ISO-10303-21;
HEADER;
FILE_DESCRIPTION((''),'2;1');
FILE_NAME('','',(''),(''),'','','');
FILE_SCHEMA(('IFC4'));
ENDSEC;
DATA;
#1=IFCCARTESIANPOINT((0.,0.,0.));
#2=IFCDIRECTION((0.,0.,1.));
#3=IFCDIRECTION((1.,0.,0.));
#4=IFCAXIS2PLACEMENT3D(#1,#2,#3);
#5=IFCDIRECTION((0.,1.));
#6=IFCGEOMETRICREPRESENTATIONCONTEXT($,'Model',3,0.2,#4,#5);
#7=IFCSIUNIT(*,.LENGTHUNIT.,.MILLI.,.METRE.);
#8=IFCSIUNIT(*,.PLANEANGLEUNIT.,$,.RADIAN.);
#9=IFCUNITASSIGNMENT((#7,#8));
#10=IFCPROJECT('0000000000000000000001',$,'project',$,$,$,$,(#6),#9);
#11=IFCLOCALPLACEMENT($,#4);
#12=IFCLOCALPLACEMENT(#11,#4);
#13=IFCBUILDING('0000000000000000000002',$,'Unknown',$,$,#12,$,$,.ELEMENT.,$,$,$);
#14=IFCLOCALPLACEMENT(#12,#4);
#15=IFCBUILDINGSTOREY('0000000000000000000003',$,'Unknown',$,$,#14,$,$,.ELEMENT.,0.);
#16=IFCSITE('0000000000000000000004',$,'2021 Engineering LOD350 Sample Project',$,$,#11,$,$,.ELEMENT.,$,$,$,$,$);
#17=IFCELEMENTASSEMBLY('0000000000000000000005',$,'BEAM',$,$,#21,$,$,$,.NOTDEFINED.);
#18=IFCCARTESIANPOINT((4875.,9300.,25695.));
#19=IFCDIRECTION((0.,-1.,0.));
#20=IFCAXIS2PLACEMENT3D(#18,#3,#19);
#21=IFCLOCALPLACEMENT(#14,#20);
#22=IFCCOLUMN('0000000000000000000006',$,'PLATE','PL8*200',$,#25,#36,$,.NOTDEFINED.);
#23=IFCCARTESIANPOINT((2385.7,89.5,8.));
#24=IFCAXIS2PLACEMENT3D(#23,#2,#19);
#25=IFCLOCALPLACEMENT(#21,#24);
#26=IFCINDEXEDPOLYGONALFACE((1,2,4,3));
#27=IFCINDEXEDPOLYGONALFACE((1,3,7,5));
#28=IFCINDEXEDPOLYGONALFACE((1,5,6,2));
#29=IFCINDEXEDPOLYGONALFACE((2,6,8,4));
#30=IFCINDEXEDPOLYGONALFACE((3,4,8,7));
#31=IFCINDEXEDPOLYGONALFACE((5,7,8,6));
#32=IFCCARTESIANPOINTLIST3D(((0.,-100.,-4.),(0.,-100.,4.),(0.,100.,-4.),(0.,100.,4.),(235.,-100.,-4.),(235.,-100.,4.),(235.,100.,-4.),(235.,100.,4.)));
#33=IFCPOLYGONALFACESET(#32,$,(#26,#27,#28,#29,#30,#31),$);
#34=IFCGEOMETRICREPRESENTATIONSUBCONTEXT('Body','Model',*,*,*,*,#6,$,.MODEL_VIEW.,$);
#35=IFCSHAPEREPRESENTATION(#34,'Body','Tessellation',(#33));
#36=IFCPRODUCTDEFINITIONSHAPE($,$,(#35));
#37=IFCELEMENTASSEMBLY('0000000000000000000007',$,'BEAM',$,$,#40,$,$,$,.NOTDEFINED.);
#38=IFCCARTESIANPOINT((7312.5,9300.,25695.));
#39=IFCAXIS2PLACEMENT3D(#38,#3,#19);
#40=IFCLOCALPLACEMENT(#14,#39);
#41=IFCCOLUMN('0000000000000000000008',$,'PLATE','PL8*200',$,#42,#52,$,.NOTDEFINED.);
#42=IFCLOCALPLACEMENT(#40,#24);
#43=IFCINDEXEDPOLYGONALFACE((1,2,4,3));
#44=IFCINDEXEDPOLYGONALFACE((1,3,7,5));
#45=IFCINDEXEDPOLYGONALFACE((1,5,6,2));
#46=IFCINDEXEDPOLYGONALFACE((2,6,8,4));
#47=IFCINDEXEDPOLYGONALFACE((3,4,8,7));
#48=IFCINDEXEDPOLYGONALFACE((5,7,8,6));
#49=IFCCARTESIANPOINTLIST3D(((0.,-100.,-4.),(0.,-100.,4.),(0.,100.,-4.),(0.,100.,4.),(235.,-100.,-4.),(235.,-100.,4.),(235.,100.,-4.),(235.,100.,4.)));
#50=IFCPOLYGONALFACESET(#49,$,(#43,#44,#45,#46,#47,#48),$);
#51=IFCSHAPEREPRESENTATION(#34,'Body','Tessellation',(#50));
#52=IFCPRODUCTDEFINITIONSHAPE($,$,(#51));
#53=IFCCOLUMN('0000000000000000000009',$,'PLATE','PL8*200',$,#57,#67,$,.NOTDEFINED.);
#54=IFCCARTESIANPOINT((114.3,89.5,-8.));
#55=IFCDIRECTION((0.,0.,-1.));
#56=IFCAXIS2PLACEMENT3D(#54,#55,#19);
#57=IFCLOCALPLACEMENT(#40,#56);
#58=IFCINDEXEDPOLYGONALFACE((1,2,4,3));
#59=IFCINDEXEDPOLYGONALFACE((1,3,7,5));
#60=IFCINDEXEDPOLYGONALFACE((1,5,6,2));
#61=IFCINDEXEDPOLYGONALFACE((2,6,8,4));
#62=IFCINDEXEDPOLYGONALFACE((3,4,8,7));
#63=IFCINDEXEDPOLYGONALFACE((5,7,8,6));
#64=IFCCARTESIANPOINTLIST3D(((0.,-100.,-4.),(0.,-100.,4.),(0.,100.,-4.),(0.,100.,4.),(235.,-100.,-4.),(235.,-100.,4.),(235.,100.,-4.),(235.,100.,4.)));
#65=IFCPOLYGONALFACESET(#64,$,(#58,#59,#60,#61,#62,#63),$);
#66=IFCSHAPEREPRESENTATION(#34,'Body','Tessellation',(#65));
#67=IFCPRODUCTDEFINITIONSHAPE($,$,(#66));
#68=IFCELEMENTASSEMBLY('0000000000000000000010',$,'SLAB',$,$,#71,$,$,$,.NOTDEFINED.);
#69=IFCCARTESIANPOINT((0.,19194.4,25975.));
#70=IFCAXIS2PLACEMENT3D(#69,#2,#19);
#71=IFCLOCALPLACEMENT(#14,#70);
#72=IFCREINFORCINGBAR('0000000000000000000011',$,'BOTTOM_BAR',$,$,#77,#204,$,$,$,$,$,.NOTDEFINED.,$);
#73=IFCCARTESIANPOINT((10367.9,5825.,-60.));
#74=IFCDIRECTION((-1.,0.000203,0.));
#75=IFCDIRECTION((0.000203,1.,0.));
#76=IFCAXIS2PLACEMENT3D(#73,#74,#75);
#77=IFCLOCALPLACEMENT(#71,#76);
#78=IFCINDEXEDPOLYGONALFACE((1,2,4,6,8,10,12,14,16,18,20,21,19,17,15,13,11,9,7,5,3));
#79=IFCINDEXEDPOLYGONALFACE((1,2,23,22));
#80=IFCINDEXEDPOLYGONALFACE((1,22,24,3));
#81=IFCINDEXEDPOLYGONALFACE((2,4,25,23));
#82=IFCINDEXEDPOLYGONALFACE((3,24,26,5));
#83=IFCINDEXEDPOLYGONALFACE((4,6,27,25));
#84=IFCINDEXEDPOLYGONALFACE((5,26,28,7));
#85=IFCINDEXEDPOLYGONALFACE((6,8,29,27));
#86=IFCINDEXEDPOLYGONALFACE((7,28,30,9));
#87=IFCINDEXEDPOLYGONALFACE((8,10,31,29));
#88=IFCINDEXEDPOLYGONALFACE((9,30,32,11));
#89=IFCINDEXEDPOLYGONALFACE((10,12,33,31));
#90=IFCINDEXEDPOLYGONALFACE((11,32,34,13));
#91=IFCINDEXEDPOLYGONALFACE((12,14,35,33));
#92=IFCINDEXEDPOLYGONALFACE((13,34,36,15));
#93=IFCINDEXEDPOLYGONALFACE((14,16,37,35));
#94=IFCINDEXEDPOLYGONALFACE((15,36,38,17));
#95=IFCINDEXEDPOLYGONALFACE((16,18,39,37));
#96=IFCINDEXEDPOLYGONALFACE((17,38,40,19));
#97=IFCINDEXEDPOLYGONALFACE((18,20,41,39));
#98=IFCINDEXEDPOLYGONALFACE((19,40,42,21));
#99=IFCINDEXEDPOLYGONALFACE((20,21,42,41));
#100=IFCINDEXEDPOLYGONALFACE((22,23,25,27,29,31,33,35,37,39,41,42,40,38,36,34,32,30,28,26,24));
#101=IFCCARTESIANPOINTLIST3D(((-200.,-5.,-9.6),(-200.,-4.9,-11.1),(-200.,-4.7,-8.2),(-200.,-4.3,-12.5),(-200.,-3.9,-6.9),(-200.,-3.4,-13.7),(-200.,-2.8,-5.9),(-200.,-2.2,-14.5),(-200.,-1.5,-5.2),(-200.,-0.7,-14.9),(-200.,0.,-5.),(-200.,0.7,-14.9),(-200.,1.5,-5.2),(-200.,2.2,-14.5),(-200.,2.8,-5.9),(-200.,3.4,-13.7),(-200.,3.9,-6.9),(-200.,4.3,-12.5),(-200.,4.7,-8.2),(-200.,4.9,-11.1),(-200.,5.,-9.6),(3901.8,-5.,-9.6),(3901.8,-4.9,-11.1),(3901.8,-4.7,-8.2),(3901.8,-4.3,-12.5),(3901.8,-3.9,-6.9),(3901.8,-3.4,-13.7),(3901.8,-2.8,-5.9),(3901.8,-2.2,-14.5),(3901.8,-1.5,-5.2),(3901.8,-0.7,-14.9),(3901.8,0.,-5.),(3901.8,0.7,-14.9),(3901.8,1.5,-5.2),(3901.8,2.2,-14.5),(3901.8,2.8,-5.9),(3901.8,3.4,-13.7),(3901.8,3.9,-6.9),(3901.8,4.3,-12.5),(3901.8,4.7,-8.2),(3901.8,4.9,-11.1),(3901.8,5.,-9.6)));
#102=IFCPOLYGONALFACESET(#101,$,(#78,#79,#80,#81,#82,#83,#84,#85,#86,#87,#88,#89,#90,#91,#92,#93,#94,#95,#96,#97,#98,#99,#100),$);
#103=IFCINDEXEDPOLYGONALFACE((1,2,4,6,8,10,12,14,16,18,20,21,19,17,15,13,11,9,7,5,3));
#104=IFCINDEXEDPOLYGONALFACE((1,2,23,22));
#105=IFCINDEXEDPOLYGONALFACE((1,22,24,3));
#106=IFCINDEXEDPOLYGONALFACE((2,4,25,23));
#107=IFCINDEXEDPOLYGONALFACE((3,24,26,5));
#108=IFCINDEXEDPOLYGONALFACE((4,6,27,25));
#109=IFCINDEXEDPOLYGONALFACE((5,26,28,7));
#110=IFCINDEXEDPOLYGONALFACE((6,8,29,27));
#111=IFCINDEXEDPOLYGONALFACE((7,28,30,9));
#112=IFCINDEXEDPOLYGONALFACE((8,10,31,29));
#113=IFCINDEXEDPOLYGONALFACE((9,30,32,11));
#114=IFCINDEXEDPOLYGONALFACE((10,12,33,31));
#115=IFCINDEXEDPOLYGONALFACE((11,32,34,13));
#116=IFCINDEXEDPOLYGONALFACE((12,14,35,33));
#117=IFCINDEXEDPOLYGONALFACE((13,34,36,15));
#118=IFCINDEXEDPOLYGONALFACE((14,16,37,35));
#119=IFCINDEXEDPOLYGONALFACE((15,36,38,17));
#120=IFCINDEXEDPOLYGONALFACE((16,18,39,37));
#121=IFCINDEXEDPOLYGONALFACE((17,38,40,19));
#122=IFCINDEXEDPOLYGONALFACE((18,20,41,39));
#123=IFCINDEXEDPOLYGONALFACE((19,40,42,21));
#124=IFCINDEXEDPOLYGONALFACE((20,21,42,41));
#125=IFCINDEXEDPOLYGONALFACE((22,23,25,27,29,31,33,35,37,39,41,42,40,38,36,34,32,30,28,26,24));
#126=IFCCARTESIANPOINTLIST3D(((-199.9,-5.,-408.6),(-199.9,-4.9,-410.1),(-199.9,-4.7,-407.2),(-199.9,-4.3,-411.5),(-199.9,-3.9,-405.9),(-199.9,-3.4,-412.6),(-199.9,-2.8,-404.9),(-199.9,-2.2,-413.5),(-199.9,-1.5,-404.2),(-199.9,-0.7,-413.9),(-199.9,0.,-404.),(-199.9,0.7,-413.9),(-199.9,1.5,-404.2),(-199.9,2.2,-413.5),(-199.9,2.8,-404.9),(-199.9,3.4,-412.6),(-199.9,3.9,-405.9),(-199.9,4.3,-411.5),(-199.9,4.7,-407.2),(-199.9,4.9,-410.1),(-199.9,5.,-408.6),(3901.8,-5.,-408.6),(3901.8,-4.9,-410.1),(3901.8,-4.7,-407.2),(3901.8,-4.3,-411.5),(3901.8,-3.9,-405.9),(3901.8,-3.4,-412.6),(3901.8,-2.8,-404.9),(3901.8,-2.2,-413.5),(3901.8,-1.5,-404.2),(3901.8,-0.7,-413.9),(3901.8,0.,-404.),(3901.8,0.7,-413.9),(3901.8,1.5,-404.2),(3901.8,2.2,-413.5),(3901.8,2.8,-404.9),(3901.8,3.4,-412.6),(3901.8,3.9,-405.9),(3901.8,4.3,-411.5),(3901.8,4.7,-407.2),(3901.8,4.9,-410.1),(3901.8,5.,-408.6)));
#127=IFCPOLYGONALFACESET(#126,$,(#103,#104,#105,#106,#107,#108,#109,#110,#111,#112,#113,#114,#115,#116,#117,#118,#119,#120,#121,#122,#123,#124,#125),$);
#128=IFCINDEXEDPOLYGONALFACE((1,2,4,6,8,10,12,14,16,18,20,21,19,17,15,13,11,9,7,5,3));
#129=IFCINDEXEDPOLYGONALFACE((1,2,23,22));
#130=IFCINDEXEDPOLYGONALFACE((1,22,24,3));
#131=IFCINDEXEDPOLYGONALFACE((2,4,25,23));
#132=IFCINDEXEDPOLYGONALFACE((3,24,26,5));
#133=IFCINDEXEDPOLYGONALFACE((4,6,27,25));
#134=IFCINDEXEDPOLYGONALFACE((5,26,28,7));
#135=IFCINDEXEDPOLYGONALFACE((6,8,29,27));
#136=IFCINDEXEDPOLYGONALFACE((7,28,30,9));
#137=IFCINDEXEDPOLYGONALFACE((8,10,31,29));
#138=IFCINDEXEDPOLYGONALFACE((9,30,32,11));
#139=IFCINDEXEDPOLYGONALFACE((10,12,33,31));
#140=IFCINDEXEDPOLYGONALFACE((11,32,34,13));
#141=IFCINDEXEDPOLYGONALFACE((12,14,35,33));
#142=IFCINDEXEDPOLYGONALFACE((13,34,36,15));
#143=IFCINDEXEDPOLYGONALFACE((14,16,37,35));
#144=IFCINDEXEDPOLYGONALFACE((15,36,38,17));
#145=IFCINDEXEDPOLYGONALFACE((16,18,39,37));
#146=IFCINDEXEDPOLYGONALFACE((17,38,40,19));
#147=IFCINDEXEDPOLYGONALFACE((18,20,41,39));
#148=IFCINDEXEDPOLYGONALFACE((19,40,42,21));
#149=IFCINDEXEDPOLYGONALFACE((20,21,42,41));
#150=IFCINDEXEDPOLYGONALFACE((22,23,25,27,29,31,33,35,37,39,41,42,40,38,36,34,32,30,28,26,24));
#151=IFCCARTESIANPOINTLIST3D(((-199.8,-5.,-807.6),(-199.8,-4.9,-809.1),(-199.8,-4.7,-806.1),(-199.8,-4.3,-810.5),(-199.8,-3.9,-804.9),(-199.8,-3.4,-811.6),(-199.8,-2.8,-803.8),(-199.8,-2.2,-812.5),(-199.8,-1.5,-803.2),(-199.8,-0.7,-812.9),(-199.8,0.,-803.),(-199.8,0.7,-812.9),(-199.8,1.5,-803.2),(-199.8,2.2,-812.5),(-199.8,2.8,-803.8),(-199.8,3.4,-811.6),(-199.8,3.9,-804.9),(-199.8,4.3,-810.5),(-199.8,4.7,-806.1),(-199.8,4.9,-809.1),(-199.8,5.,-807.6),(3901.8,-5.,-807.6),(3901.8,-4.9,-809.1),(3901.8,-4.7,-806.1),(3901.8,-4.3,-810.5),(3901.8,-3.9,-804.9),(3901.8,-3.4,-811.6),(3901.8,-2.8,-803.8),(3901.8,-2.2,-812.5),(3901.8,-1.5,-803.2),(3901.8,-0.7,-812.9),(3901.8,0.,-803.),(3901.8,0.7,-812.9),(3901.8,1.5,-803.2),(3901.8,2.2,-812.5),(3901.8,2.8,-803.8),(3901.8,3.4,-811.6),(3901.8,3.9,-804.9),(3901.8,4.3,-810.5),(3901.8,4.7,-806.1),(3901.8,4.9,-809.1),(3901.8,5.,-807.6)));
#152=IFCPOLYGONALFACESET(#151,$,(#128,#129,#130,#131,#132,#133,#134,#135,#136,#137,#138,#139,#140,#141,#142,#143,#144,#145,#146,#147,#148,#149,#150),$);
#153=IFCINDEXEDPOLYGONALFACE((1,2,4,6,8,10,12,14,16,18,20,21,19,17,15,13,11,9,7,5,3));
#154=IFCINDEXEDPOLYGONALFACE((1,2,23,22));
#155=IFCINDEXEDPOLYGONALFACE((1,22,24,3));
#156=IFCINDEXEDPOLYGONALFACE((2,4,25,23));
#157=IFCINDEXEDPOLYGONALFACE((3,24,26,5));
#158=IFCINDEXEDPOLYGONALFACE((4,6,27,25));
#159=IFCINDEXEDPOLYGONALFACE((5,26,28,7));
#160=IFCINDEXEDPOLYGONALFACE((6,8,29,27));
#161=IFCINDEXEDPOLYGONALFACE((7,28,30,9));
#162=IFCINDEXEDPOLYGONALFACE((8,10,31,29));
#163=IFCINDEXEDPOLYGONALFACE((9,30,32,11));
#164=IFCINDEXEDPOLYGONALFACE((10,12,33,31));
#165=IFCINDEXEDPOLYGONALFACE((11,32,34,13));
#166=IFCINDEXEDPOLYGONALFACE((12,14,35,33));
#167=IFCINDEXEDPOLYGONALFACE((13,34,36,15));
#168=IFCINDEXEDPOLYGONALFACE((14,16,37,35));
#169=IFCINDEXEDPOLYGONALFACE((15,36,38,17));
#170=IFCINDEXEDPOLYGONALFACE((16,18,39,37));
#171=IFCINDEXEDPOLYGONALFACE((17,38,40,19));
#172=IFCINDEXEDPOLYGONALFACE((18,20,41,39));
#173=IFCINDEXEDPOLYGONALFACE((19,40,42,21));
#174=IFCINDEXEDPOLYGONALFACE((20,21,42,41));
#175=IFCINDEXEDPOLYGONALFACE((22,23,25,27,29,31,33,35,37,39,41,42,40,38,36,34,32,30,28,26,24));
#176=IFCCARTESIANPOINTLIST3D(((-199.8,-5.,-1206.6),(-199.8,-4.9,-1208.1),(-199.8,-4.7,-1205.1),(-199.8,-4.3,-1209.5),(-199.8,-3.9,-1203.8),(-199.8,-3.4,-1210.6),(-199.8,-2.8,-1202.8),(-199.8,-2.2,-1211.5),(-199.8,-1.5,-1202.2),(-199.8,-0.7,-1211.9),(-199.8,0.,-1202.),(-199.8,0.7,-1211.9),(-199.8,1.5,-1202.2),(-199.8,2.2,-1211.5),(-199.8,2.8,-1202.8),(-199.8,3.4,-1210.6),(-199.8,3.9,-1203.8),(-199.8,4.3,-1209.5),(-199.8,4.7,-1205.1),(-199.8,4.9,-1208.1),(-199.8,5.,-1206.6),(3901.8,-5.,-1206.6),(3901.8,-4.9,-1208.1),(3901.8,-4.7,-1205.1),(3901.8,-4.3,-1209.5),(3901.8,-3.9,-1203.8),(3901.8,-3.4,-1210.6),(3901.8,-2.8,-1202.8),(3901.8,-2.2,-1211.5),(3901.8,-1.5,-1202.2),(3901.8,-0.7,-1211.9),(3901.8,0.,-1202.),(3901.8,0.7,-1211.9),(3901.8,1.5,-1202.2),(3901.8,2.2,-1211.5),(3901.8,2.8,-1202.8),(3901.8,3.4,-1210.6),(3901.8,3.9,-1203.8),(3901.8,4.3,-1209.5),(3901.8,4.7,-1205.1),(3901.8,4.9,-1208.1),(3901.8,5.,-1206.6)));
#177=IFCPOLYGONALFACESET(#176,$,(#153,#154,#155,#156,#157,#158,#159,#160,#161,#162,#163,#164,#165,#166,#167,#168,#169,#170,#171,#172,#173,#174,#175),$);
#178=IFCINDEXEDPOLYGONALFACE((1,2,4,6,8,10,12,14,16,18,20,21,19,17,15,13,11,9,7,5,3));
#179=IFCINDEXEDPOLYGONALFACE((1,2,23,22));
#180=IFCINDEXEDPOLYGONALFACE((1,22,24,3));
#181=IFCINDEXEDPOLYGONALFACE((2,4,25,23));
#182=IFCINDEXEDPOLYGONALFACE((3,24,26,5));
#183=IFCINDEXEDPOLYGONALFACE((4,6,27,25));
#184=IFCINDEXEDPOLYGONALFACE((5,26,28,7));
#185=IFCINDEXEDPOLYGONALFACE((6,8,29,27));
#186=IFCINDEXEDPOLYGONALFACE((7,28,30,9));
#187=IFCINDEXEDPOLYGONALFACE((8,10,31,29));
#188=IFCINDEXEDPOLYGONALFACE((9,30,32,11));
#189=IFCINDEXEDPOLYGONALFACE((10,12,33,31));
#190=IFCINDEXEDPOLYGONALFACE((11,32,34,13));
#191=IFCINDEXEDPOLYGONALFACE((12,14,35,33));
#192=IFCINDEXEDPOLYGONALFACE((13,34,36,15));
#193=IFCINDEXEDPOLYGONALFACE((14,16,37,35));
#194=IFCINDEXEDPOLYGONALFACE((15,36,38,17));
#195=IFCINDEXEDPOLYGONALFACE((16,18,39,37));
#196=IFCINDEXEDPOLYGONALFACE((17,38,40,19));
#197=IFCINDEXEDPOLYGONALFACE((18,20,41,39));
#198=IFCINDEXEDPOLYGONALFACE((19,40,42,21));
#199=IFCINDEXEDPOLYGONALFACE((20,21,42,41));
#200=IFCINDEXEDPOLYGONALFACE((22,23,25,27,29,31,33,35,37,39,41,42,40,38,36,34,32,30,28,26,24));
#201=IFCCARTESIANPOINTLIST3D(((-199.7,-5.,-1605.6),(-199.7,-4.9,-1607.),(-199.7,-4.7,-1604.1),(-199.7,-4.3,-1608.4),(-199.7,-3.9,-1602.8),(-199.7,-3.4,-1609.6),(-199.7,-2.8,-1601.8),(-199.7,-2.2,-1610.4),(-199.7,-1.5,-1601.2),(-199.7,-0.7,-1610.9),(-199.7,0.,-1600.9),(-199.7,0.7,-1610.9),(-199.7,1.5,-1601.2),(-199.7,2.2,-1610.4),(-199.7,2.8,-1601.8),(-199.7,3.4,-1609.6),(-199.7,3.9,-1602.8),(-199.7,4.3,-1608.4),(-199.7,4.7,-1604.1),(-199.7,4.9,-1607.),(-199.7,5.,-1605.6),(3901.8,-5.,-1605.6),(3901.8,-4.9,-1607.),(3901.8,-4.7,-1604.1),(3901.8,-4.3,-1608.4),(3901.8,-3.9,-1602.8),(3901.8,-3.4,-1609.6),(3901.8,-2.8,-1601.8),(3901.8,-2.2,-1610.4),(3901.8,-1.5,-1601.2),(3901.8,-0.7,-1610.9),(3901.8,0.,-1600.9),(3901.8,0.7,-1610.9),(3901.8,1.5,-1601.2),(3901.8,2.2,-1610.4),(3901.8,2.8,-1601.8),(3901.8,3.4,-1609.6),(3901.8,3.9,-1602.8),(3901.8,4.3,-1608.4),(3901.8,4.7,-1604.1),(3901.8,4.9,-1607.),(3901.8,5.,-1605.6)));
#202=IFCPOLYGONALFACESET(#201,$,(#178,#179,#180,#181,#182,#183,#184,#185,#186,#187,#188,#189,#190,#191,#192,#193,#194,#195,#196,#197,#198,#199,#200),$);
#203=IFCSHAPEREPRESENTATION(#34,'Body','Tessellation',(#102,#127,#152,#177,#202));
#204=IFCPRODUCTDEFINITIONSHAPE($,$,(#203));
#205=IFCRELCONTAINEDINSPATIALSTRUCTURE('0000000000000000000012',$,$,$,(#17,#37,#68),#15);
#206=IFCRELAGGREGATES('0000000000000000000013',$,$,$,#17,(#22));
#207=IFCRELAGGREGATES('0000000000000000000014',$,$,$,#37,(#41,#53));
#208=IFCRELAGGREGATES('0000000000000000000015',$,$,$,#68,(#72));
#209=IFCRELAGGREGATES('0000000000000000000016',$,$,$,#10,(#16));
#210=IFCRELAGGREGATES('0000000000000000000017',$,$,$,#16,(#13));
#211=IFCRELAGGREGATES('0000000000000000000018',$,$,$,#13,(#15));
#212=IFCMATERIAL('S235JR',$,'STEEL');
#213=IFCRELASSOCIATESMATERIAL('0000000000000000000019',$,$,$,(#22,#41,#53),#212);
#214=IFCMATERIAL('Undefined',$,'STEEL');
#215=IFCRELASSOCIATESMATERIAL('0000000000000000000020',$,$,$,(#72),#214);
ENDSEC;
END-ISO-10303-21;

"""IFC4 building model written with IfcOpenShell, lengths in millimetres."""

from ifc_helpers import new_model, entity, si_unit, direction, frame, origin_with_axes, place, context, subcontext, project, spatial, line, indexed_curve, outline, extrude, material, element, aggregate, save


model = new_model("IFC4")

# Units and contexts
model_context = context("Model", 3, precision=0.2, world=origin_with_axes(), true_north=direction((0.0, 1.0)))
body_context = subcontext(model_context, "Body", "Model", "MODEL_VIEW")
ifc_project = project(units=[si_unit("LENGTHUNIT", "METRE", prefix="MILLI"), si_unit("PLANEANGLEUNIT", "RADIAN")], contexts=[model_context])

# Site, building, storey
site_placement = place(None, origin_with_axes())
site = spatial("IfcSite", under=ifc_project, at=site_placement, Name="2021 Engineering LOD350 Sample Project", CompositionType="ELEMENT")
building_placement = place(site_placement, origin_with_axes())
building = spatial("IfcBuilding", under=site, at=building_placement, Name="Unknown", CompositionType="ELEMENT")
storey_placement = place(building_placement, origin_with_axes())
storey = spatial("IfcBuildingStorey", under=building, at=storey_placement, Name="Unknown", CompositionType="ELEMENT", Elevation=0.0)

# Element assembly, column
assembly_1_placement = place(storey_placement, frame((4875.0, 9300.0, 25695.0), z_axis=(1.0, 0.0, 0.0), x_axis=(0.0, -1.0, 0.0)))
assembly_1 = element("IfcElementAssembly", 1, at=assembly_1_placement, inside=storey, Name="BEAM", PredefinedType="NOTDEFINED")
ifc_material_1 = material(Name="S235JR", Category="STEEL")
column_1_placement = place(assembly_1_placement, frame((2385.7, 89.5, 8.0), z_axis=(0.0, 0.0, 1.0), x_axis=(0.0, -1.0, 0.0)))
column_1 = element("IfcColumn", 2, at=column_1_placement, material=ifc_material_1, Name="PLATE", Description="PL8*200", PredefinedType="NOTDEFINED", context=body_context, shape_type="SolidModel", body=[
    extrude(outline(indexed_curve([(-4.0, -100.0), (4.0, -100.0), (4.0, 100.0), (-4.0, 100.0)], segments=[line(1, 2, 3, 4, 1)])), frame((0.0, 0.0, 0.0), z_axis=(-1.0, 0.0, 0.0), x_axis=(0.0, 0.0, 1.0)), (0.0, 0.0, -1.0), 235.0),
])
aggregate(assembly_1, [column_1])

# Element assembly, columns
assembly_2_placement = place(storey_placement, frame((7312.5, 9300.0, 25695.0), z_axis=(1.0, 0.0, 0.0), x_axis=(0.0, -1.0, 0.0)))
assembly_2 = element("IfcElementAssembly", 3, at=assembly_2_placement, inside=storey, Name="BEAM", PredefinedType="NOTDEFINED")
column_2_placement = place(assembly_2_placement, frame((2385.7, 89.5, 8.0), z_axis=(0.0, 0.0, 1.0), x_axis=(0.0, -1.0, 0.0)))
column_2 = element("IfcColumn", 4, at=column_2_placement, material=ifc_material_1, Name="PLATE", Description="PL8*200", PredefinedType="NOTDEFINED", context=body_context, shape_type="SolidModel", body=[
    extrude(outline(indexed_curve([(-4.0, -100.0), (4.0, -100.0), (4.0, 100.0), (-4.0, 100.0)], segments=[line(1, 2, 3, 4, 1)])), frame((0.0, 0.0, 0.0), z_axis=(-1.0, 0.0, 0.0), x_axis=(0.0, 0.0, 1.0)), (0.0, 0.0, -1.0), 235.0),
])
column_3_placement = place(assembly_2_placement, frame((114.3, 89.5, -8.0), z_axis=(0.0, 0.0, -1.0), x_axis=(0.0, -1.0, 0.0)))
column_3 = element("IfcColumn", 5, at=column_3_placement, material=ifc_material_1, Name="PLATE", Description="PL8*200", PredefinedType="NOTDEFINED", context=body_context, shape_type="SolidModel", body=[
    extrude(outline(indexed_curve([(-4.0, -100.0), (4.0, -100.0), (4.0, 100.0), (-4.0, 100.0)], segments=[line(1, 2, 3, 4, 1)])), frame((0.0, 0.0, 0.0), z_axis=(-1.0, 0.0, 0.0), x_axis=(0.0, 0.0, 1.0)), (0.0, 0.0, -1.0), 235.0),
])

aggregate(assembly_2, [column_2, column_3])

# Element assembly
assembly_3_placement = place(storey_placement, frame((0.0, 19194.4, 25975.0), z_axis=(0.0, 0.0, 1.0), x_axis=(0.0, -1.0, 0.0)))
assembly_3 = element("IfcElementAssembly", 6, at=assembly_3_placement, inside=storey, Name="SLAB", PredefinedType="NOTDEFINED")
ifc_material_2 = material(Name="Undefined", Category="STEEL")

# Reinforcing bar
reinforcing_bar_1_placement = place(assembly_3_placement, frame((10367.9, 5825.0, -60.0), z_axis=(-1.0, 0.000203, 0.0), x_axis=(0.000203, 1.0, 0.0)))
reinforcing_bar_1 = element("IfcReinforcingBar", 7, at=reinforcing_bar_1_placement, material=ifc_material_2, Name="BOTTOM_BAR", PredefinedType="NOTDEFINED", context=body_context, shape_type="AdvancedSweptSolid", body=[
    entity("IfcSweptDiskSolid", entity("IfcIndexedPolyCurve", entity("IfcCartesianPointList3D", [[-200.0, 0.0, -10.0], [3901.8, 0.0, -10.0]]), [entity("IfcLineIndex", [1, 2])]), 5.0),
    entity("IfcSweptDiskSolid", entity("IfcIndexedPolyCurve", entity("IfcCartesianPointList3D", [[-199.9, 0.0, -409.0], [3901.8, 0.0, -409.0]]), [entity("IfcLineIndex", [1, 2])]), 5.0),
    entity("IfcSweptDiskSolid", entity("IfcIndexedPolyCurve", entity("IfcCartesianPointList3D", [[-199.8, 0.0, -808.0], [3901.8, 0.0, -808.0]]), [entity("IfcLineIndex", [1, 2])]), 5.0),
    entity("IfcSweptDiskSolid", entity("IfcIndexedPolyCurve", entity("IfcCartesianPointList3D", [[-199.8, 0.0, -1207.0], [3901.8, 0.0, -1207.0]]), [entity("IfcLineIndex", [1, 2])]), 5.0),
    entity("IfcSweptDiskSolid", entity("IfcIndexedPolyCurve", entity("IfcCartesianPointList3D", [[-199.7, 0.0, -1605.9], [3901.8, 0.0, -1605.9]]), [entity("IfcLineIndex", [1, 2])]), 5.0),
])
aggregate(assembly_3, [reinforcing_bar_1])

save(model, "model.ifc")
